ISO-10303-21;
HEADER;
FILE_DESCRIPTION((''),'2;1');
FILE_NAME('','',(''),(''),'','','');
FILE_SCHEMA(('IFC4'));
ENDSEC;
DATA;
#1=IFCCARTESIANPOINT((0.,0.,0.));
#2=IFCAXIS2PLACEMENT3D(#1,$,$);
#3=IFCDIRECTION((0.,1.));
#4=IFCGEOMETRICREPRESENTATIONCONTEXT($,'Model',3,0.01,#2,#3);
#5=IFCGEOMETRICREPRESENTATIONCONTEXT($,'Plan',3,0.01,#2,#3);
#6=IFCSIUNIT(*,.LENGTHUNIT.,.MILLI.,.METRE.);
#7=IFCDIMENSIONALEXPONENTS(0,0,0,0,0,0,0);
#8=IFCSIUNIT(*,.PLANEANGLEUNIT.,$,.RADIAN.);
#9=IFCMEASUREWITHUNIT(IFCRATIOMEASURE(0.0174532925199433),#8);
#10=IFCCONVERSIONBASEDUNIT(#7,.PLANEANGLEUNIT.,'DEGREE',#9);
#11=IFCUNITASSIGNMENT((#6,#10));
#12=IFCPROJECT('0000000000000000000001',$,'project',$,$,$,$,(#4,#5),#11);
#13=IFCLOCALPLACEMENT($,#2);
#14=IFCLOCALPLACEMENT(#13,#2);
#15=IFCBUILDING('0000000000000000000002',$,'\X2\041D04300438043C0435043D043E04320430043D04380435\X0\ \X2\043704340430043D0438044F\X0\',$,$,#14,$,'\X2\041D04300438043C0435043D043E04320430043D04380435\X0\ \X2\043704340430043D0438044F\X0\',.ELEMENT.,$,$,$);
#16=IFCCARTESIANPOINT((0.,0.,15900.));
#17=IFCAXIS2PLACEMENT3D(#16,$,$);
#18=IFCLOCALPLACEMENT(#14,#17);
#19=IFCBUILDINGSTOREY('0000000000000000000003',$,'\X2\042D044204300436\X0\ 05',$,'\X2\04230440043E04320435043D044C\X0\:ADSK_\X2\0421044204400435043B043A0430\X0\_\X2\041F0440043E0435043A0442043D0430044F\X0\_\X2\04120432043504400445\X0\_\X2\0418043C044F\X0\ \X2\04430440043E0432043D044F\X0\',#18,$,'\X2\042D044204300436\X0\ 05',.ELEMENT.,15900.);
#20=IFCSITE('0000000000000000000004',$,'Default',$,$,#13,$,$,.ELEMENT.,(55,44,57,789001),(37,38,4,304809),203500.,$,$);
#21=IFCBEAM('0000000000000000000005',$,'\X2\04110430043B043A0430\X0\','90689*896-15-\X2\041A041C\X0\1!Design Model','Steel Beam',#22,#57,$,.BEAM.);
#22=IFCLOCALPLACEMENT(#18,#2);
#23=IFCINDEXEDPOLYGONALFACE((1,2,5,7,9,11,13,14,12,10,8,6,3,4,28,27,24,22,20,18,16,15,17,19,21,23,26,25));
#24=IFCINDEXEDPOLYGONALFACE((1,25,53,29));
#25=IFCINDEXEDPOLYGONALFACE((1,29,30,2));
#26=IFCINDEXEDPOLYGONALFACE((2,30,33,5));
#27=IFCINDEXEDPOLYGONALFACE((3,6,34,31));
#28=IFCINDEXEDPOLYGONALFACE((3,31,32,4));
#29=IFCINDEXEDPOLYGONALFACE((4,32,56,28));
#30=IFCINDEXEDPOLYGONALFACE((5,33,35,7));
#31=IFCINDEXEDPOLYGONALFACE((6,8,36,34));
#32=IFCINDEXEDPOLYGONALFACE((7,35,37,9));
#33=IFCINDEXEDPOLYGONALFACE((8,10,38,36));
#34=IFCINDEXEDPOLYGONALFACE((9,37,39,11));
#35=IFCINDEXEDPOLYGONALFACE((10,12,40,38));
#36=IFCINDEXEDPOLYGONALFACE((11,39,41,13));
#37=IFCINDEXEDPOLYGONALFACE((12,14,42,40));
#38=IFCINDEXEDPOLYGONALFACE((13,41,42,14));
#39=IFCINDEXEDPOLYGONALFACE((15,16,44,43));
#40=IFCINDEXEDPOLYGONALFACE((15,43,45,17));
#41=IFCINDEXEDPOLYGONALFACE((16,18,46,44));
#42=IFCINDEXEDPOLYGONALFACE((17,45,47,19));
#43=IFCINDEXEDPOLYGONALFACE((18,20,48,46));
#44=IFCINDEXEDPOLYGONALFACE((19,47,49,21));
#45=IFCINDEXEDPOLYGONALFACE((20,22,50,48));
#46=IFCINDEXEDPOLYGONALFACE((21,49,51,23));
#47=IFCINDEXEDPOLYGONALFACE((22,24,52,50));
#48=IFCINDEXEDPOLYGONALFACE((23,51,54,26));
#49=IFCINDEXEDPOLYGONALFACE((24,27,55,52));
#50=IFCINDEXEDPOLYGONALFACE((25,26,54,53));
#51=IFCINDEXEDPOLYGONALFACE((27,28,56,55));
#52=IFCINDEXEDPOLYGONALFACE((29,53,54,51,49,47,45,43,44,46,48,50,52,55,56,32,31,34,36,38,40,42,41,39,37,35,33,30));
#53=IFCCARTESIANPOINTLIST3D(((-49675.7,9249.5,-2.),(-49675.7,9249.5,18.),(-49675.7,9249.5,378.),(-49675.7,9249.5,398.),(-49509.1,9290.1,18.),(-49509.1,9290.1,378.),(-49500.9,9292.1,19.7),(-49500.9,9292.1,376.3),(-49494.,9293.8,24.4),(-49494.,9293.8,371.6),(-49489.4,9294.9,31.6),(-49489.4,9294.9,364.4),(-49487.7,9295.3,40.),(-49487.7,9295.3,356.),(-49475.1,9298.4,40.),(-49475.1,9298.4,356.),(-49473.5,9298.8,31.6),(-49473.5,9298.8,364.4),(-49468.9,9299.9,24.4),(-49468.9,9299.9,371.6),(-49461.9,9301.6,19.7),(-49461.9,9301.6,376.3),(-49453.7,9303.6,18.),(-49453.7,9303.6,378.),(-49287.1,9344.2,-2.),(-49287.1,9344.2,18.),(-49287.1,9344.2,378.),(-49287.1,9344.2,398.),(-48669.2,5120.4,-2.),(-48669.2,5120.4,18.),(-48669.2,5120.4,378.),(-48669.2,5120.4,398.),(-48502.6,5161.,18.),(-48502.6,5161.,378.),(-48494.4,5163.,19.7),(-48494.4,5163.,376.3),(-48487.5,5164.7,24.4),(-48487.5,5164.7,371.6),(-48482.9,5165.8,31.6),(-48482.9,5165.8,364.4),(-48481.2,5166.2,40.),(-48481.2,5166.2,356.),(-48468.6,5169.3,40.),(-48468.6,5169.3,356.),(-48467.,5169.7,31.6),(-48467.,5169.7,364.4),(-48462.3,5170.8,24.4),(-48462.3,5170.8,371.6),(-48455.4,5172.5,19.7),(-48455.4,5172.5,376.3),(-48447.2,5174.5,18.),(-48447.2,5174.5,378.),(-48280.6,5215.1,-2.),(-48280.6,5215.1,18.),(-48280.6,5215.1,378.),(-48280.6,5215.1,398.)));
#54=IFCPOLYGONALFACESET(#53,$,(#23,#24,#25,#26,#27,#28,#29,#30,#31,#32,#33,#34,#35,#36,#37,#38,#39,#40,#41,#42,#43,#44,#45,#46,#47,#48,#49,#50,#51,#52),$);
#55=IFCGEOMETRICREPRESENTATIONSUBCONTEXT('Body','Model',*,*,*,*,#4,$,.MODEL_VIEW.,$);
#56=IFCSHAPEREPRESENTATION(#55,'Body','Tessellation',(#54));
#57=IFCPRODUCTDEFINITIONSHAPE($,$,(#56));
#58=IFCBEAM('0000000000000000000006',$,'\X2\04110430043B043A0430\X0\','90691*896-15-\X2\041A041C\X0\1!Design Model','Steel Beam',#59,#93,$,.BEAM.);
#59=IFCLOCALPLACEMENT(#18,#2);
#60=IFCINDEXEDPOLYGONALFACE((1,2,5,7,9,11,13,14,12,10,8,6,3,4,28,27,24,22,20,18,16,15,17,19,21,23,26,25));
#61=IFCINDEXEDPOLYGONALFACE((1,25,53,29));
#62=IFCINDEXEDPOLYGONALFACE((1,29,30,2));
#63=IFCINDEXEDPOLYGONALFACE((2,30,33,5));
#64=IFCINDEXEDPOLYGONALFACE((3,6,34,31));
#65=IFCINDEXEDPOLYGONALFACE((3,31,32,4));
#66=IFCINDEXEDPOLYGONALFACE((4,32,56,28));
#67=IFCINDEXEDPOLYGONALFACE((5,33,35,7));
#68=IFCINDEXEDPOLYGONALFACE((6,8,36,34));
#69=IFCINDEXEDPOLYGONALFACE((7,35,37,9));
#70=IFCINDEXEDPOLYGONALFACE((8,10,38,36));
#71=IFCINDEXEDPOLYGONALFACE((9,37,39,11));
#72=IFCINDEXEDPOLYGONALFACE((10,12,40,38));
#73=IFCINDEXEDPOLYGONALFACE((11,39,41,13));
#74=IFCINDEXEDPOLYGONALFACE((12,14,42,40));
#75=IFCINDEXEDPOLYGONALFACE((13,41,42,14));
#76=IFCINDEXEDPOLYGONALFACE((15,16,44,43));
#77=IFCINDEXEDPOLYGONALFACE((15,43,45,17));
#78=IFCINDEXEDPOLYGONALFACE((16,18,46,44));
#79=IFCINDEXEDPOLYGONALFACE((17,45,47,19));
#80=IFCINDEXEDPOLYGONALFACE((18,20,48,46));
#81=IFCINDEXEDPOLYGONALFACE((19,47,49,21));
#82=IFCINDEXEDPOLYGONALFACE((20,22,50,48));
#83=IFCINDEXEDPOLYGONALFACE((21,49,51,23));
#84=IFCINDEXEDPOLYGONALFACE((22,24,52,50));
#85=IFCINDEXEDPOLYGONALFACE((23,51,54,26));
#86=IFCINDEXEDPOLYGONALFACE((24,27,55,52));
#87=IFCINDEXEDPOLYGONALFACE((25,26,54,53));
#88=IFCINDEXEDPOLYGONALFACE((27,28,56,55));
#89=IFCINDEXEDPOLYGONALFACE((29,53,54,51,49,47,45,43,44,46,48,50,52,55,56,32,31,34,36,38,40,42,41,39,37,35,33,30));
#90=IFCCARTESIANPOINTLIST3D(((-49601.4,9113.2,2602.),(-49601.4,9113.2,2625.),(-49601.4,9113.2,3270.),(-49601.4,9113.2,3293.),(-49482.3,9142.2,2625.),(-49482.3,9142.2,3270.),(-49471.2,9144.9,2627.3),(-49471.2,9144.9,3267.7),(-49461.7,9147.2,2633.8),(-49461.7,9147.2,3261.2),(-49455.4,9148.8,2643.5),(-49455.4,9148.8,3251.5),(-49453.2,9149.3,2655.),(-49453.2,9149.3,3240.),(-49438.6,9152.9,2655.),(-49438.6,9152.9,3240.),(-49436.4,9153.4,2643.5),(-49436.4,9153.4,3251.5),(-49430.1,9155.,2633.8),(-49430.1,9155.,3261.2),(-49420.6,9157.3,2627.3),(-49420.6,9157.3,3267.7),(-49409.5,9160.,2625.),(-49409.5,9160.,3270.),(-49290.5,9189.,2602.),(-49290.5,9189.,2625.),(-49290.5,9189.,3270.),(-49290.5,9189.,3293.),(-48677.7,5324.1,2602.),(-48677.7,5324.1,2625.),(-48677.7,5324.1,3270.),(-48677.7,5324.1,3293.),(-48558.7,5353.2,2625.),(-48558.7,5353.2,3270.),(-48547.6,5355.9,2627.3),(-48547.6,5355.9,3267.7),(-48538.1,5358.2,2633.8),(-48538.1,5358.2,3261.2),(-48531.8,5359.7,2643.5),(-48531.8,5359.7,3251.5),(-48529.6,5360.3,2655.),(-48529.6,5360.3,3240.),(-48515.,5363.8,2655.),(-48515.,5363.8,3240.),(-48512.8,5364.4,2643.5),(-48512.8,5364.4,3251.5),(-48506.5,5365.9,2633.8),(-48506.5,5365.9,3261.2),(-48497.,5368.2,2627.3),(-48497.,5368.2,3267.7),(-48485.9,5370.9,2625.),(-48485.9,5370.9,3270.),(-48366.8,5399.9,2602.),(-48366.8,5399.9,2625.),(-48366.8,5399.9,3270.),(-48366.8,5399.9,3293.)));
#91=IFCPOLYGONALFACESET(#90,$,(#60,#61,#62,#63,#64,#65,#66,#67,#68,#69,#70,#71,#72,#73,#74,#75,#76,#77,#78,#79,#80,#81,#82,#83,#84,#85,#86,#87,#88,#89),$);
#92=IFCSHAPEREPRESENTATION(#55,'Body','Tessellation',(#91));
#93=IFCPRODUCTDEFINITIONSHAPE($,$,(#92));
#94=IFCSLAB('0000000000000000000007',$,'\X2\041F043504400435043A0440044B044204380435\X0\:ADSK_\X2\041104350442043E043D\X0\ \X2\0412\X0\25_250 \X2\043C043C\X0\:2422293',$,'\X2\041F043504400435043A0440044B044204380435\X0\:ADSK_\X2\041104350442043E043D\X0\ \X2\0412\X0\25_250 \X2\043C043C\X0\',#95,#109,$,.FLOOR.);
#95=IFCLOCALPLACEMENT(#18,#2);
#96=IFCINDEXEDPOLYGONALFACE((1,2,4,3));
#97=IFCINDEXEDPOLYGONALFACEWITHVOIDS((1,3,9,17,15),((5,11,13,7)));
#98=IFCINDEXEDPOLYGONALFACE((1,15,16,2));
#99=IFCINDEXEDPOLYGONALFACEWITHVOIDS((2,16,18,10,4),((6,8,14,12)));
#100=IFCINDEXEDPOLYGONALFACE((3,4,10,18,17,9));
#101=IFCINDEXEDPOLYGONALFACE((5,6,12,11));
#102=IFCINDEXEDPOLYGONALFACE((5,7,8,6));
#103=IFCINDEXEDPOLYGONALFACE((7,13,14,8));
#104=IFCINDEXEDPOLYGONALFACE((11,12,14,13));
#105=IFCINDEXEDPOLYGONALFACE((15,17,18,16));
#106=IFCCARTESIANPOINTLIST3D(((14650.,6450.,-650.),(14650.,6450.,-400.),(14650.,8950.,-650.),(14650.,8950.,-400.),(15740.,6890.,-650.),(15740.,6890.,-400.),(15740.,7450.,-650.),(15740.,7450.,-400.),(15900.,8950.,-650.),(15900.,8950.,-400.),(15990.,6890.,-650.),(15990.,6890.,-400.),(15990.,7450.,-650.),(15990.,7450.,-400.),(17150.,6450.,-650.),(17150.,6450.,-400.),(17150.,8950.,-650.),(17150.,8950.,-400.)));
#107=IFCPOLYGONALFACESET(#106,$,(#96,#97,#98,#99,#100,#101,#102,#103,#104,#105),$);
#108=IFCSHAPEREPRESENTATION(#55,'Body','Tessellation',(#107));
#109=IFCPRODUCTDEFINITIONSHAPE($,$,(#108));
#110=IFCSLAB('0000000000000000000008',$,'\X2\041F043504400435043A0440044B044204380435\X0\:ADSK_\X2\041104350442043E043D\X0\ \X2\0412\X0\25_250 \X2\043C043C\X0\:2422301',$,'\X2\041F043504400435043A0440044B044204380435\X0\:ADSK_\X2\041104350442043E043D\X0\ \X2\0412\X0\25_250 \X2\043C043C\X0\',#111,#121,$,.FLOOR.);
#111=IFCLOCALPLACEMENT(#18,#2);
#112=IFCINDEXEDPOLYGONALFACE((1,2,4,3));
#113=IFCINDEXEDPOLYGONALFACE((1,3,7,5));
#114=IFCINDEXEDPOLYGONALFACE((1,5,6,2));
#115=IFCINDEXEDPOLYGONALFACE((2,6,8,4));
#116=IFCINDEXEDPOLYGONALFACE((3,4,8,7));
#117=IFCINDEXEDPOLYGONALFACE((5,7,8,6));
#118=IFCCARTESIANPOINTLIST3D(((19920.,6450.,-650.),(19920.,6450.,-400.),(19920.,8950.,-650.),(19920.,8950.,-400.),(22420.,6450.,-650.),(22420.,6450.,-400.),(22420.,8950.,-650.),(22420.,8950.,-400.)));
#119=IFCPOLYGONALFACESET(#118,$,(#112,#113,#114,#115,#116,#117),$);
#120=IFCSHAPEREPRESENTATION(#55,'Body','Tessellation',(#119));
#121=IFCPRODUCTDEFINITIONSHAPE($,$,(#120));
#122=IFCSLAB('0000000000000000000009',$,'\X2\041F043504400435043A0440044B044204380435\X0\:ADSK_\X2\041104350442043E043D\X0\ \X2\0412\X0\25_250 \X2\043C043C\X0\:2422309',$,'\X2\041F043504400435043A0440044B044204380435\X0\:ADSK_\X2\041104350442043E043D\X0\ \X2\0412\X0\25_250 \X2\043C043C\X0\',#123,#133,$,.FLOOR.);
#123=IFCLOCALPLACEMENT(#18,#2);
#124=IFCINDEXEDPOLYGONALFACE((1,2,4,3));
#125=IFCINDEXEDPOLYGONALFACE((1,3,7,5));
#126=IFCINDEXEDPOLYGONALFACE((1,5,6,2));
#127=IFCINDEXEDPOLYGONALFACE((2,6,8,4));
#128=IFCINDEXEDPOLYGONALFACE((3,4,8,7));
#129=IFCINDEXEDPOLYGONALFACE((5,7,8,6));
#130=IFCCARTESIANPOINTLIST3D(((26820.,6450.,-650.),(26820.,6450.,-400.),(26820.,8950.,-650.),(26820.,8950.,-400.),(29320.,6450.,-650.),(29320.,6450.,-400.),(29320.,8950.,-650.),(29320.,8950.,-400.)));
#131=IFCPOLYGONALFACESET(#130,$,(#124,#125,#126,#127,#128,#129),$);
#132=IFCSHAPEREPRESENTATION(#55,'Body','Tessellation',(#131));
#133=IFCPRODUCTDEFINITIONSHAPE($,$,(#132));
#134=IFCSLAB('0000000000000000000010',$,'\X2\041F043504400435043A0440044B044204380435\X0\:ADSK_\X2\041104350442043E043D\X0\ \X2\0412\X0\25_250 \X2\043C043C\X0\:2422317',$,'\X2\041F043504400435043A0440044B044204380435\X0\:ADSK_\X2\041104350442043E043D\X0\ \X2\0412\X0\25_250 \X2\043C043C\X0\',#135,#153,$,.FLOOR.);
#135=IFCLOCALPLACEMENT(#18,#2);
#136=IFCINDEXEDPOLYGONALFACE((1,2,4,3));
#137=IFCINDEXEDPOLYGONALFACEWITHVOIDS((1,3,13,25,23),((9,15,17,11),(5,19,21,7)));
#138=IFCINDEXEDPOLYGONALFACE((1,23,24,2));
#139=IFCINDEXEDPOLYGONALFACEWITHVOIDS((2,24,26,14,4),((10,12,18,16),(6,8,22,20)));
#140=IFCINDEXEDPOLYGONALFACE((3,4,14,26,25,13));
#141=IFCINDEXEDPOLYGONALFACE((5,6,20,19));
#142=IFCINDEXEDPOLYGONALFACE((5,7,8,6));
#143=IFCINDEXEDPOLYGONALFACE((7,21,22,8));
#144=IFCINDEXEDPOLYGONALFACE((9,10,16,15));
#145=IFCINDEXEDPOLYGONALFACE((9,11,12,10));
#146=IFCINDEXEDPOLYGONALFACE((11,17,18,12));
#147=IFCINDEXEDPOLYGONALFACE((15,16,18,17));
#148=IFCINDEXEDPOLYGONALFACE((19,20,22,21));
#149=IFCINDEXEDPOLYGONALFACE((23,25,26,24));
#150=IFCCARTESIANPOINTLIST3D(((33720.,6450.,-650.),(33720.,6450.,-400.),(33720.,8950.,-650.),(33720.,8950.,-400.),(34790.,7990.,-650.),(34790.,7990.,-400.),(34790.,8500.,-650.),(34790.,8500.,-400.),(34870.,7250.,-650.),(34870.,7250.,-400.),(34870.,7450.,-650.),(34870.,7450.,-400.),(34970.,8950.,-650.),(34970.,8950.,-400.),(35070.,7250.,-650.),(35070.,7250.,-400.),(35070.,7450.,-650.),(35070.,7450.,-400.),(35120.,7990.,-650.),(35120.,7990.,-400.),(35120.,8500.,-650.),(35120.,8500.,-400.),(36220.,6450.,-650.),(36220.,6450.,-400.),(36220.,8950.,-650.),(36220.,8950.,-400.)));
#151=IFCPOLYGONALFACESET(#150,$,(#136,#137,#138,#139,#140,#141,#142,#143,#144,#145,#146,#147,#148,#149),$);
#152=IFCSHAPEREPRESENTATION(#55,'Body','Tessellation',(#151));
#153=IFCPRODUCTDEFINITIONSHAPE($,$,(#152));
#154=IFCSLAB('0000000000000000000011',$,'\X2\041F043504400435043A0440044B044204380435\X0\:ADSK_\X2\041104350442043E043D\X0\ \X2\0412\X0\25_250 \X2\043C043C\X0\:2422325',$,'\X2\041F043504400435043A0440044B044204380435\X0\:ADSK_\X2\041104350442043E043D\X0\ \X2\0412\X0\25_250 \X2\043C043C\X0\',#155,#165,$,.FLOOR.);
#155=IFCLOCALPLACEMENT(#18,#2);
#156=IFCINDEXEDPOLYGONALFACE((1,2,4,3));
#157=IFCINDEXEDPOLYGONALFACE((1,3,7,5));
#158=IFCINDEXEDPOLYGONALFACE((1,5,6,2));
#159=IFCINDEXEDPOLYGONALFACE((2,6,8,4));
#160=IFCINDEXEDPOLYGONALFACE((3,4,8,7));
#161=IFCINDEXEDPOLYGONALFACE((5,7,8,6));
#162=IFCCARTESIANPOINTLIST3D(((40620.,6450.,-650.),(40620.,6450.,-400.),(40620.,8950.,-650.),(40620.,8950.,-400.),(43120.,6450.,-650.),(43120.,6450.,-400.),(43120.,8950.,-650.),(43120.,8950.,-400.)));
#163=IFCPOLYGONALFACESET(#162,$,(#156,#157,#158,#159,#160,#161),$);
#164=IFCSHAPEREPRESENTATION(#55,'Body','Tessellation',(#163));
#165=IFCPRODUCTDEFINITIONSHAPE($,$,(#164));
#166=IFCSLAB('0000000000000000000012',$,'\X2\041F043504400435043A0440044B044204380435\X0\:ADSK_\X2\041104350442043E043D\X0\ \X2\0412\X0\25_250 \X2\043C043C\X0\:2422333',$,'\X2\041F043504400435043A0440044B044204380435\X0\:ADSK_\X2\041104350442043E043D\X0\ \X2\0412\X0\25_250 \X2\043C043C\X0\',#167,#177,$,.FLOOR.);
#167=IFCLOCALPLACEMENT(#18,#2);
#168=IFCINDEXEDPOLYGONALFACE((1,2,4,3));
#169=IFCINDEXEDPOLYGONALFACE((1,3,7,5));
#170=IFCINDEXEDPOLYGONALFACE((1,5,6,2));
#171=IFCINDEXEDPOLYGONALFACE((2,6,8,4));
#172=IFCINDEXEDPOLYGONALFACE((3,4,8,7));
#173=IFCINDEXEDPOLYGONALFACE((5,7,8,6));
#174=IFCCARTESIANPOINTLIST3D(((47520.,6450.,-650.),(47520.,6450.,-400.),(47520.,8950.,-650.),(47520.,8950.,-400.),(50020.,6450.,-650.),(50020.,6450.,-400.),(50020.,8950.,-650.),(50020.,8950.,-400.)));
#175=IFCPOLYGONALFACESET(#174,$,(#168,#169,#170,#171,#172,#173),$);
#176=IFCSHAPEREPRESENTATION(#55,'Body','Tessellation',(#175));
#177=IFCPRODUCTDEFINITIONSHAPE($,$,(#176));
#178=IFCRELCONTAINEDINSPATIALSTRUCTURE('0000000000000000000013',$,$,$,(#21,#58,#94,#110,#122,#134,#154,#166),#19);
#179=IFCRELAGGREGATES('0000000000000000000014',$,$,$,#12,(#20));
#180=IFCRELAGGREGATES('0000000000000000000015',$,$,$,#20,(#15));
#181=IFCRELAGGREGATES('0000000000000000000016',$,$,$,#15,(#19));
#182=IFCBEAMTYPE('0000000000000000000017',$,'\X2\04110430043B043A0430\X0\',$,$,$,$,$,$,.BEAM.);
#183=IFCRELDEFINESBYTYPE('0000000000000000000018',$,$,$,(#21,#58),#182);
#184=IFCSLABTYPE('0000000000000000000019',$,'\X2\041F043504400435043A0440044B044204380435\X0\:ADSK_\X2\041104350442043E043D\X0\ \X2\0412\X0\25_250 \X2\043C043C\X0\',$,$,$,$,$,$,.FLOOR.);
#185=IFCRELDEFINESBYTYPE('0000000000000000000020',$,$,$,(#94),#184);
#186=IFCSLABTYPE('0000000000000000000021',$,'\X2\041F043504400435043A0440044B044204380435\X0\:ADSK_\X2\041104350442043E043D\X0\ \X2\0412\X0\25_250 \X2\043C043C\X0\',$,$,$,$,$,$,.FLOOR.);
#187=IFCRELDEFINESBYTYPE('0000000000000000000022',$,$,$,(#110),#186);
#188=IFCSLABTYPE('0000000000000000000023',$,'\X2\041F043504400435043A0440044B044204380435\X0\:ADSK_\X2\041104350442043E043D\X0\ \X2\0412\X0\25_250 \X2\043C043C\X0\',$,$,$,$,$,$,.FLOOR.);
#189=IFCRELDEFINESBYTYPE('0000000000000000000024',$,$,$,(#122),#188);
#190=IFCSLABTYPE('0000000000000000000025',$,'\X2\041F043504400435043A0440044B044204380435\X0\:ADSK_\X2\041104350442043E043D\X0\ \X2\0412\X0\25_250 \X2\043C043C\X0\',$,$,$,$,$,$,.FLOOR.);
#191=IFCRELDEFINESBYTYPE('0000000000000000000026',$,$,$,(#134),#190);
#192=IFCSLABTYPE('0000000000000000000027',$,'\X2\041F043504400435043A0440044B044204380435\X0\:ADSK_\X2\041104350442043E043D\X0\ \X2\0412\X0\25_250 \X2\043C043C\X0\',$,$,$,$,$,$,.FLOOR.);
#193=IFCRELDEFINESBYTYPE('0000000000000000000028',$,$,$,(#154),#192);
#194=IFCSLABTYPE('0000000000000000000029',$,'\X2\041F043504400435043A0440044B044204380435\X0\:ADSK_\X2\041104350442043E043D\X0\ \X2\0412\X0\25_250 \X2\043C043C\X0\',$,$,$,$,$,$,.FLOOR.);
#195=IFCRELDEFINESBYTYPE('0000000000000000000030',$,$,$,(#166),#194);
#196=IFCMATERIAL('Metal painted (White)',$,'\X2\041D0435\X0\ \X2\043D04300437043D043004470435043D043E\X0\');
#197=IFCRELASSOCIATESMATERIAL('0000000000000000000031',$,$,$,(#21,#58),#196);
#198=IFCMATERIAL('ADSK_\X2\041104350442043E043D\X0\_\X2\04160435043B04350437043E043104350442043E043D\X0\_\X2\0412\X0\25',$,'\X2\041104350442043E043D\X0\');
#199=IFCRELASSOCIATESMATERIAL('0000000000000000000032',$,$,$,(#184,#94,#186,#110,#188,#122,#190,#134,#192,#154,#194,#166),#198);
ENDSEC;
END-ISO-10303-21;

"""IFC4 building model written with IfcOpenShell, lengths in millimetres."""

from ifc_helpers import new_model, entity, si_unit, converted_unit, direction, frame, origin, place, context, subcontext, project, spatial, indexed_curve, outline, extrude, material, type_object, element, save


model = new_model("IFC4")

# Units and contexts
model_context = context("Model", 3, precision=0.01, world=origin(), true_north=direction((0.0, 1.0)))
plan_context = context("Plan", 3, precision=0.01, world=origin(), true_north=direction((0.0, 1.0)))
body_context = subcontext(model_context, "Body", "Model", "MODEL_VIEW")
ifc_project = project(units=[si_unit("LENGTHUNIT", "METRE", prefix="MILLI"), converted_unit("PLANEANGLEUNIT", "DEGREE", entity("IfcRatioMeasure", 0.0174532925199433), si_unit("PLANEANGLEUNIT", "RADIAN"), dimensions=[0, 0, 0, 0, 0, 0, 0])], contexts=[model_context, plan_context])

# Site, building, storey
site_placement = place(None, origin())
site = spatial("IfcSite", under=ifc_project, at=site_placement, Name="Default", CompositionType="ELEMENT", RefLatitude=(55, 44, 57, 789001), RefLongitude=(37, 38, 4, 304809), RefElevation=203500.0)
building_placement = place(site_placement, origin())
building = spatial("IfcBuilding", under=site, at=building_placement, Name="Наименование здания", LongName="Наименование здания", CompositionType="ELEMENT")
storey_placement = place(building_placement, frame((0.0, 0.0, 15900.0)))
storey = spatial("IfcBuildingStorey", under=building, at=storey_placement, Name="Этаж 05", ObjectType="Уровень:ADSK_Стрелка_Проектная_Вверх_Имя уровня", LongName="Этаж 05", CompositionType="ELEMENT", Elevation=15900.0)

# Shared definitions
placement = place(storey_placement, origin())

# Beams
ifc_material_1 = material(Name="Metal painted (White)", Category="Не назначено")
beam_type = type_object("IfcBeamType", Name="Балка", PredefinedType="BEAM")
element("IfcBeam", 1, at=placement, inside=storey, type_object=beam_type, material=ifc_material_1, Name="Балка", Description="90689*896-15-КМ1!Design Model", ObjectType="Steel Beam", PredefinedType="BEAM", context=body_context, shape_type="SweptSolid", body=[
    extrude(outline(indexed_curve([(-200.0, -200.0), (-180.0, -200.0), (-180.0, -28.5), (-178.3, -20.1), (-173.6, -12.9), (-166.4, -8.2), (-158.0, -6.5), (158.0, -6.5), (166.4, -8.2), (173.6, -12.9), (178.3, -20.1), (180.0, -28.5), (180.0, -200.0), (200.0, -200.0), (200.0, 200.0), (180.0, 200.0), (180.0, 28.5), (178.3, 20.1), (173.6, 12.9), (166.4, 8.2), (158.0, 6.5), (-158.0, 6.5), (-166.4, 8.2), (-173.6, 12.9), (-178.3, 20.1), (-180.0, 28.5), (-180.0, 200.0), (-200.0, 200.0), (-200.0, -200.0)], self_intersect=False)), frame((-48474.9, 5167.7, 198.0), z_axis=(-0.236826, 0.971552, 0.0), x_axis=(0.0, 0.0, 1.0)), (0.0, 0.0, 1.0), 4250.0),
])
element("IfcBeam", 2, at=placement, inside=storey, type_object=beam_type, material=ifc_material_1, Name="Балка", Description="90691*896-15-КМ1!Design Model", ObjectType="Steel Beam", PredefinedType="BEAM", context=body_context, shape_type="SweptSolid", body=[
    extrude(outline(indexed_curve([(-345.5, -160.0), (-322.5, -160.0), (-322.5, -37.5), (-320.2, -26.0), (-313.7, -16.3), (-304.0, -9.8), (-292.5, -7.5), (292.5, -7.5), (304.0, -9.8), (313.7, -16.3), (320.2, -26.0), (322.5, -37.5), (322.5, -160.0), (345.5, -160.0), (345.5, 160.0), (322.5, 160.0), (322.5, 37.5), (320.2, 26.0), (313.7, 16.3), (304.0, 9.8), (292.5, 7.5), (-292.5, 7.5), (-304.0, 9.8), (-313.7, 16.3), (-320.2, 26.0), (-322.5, 37.5), (-322.5, 160.0), (-345.5, 160.0), (-345.5, -160.0)], self_intersect=False)), frame((-48522.3, 5362.0, 2947.5), z_axis=(-0.236826, 0.971552, 0.0), x_axis=(0.0, 0.0, 1.0)), (0.0, 0.0, 1.0), 3900.0),
])

# Slabs
ifc_material_2 = material(Name="ADSK_Бетон_Железобетон_В25", Category="Бетон")
slab_type_1 = type_object("IfcSlabType", Name="Перекрытие:ADSK_Бетон В25_250 мм", PredefinedType="FLOOR", material=ifc_material_2)
element("IfcSlab", 3, at=placement, inside=storey, type_object=slab_type_1, material=ifc_material_2, Name="Перекрытие:ADSK_Бетон В25_250 мм:2422293", ObjectType="Перекрытие:ADSK_Бетон В25_250 мм", PredefinedType="FLOOR", context=body_context, shape_type="SweptSolid", body=[
    extrude(outline(indexed_curve([(-1000.0, -1250.0), (1500.0, -1250.0), (1500.0, 1250.0), (-1000.0, 1250.0), (-1000.0, 0.0), (-1000.0, -1250.0)], self_intersect=False), holes=[indexed_curve([(500.0, 90.0), (1060.0, 90.0), (1060.0, -160.0), (500.0, -160.0), (500.0, 90.0)], self_intersect=False)]), frame((15900.0, 7950.0, -650.0), z_axis=(0.0, 0.0, 1.0), x_axis=(0.0, -1.0, 0.0)), (0.0, 0.0, 1.0), 250.0),
])
slab_type_2 = type_object("IfcSlabType", Name="Перекрытие:ADSK_Бетон В25_250 мм", PredefinedType="FLOOR", material=ifc_material_2)
element("IfcSlab", 4, at=placement, inside=storey, type_object=slab_type_2, material=ifc_material_2, Name="Перекрытие:ADSK_Бетон В25_250 мм:2422301", ObjectType="Перекрытие:ADSK_Бетон В25_250 мм", PredefinedType="FLOOR", context=body_context, shape_type="SweptSolid", body=[
    extrude(outline(indexed_curve([(-1250.0, -1250.0), (1250.0, -1250.0), (1250.0, 1250.0), (-1250.0, 1250.0), (-1250.0, -1250.0)], self_intersect=False)), frame((21170.0, 7700.0, -400.0), z_axis=(0.0, 0.0, -1.0), x_axis=(0.0, 1.0, 0.0)), (0.0, 0.0, 1.0), 250.0),
])
slab_type_3 = type_object("IfcSlabType", Name="Перекрытие:ADSK_Бетон В25_250 мм", PredefinedType="FLOOR", material=ifc_material_2)
element("IfcSlab", 5, at=placement, inside=storey, type_object=slab_type_3, material=ifc_material_2, Name="Перекрытие:ADSK_Бетон В25_250 мм:2422309", ObjectType="Перекрытие:ADSK_Бетон В25_250 мм", PredefinedType="FLOOR", context=body_context, shape_type="SweptSolid", body=[
    extrude(outline(indexed_curve([(-1250.0, -1250.0), (1250.0, -1250.0), (1250.0, 1250.0), (-1250.0, 1250.0), (-1250.0, -1250.0)], self_intersect=False)), frame((28070.0, 7700.0, -400.0), z_axis=(0.0, 0.0, -1.0), x_axis=(0.0, 1.0, 0.0)), (0.0, 0.0, 1.0), 250.0),
])
slab_type_4 = type_object("IfcSlabType", Name="Перекрытие:ADSK_Бетон В25_250 мм", PredefinedType="FLOOR", material=ifc_material_2)
element("IfcSlab", 6, at=placement, inside=storey, type_object=slab_type_4, material=ifc_material_2, Name="Перекрытие:ADSK_Бетон В25_250 мм:2422317", ObjectType="Перекрытие:ADSK_Бетон В25_250 мм", PredefinedType="FLOOR", context=body_context, shape_type="SweptSolid", body=[
    extrude(outline(indexed_curve([(-1000.0, -1250.0), (1500.0, -1250.0), (1500.0, 1250.0), (-1000.0, 1250.0), (-1000.0, 0.0), (-1000.0, -1250.0)], self_intersect=False), holes=[indexed_curve([(500.0, 100.0), (700.0, 100.0), (700.0, -100.0), (500.0, -100.0), (500.0, 100.0)], self_intersect=False), indexed_curve([(-550.0, 150.0), (-40.0, 150.0), (-40.0, -180.0), (-550.0, -180.0), (-550.0, 150.0)], self_intersect=False)]), frame((34970.0, 7950.0, -650.0), z_axis=(0.0, 0.0, 1.0), x_axis=(0.0, -1.0, 0.0)), (0.0, 0.0, 1.0), 250.0),
])
slab_type_5 = type_object("IfcSlabType", Name="Перекрытие:ADSK_Бетон В25_250 мм", PredefinedType="FLOOR", material=ifc_material_2)
element("IfcSlab", 7, at=placement, inside=storey, type_object=slab_type_5, material=ifc_material_2, Name="Перекрытие:ADSK_Бетон В25_250 мм:2422325", ObjectType="Перекрытие:ADSK_Бетон В25_250 мм", PredefinedType="FLOOR", context=body_context, shape_type="SweptSolid", body=[
    extrude(outline(indexed_curve([(-1250.0, -1250.0), (1250.0, -1250.0), (1250.0, 1250.0), (-1250.0, 1250.0), (-1250.0, -1250.0)], self_intersect=False)), frame((41870.0, 7700.0, -400.0), z_axis=(0.0, 0.0, -1.0), x_axis=(0.0, 1.0, 0.0)), (0.0, 0.0, 1.0), 250.0),
])
slab_type_6 = type_object("IfcSlabType", Name="Перекрытие:ADSK_Бетон В25_250 мм", PredefinedType="FLOOR", material=ifc_material_2)
element("IfcSlab", 8, at=placement, inside=storey, type_object=slab_type_6, material=ifc_material_2, Name="Перекрытие:ADSK_Бетон В25_250 мм:2422333", ObjectType="Перекрытие:ADSK_Бетон В25_250 мм", PredefinedType="FLOOR", context=body_context, shape_type="SweptSolid", body=[
    extrude(outline(indexed_curve([(-1250.0, -1250.0), (1250.0, -1250.0), (1250.0, 1250.0), (-1250.0, 1250.0), (-1250.0, -1250.0)], self_intersect=False)), frame((48770.0, 7700.0, -400.0), z_axis=(0.0, 0.0, -1.0), x_axis=(0.0, 1.0, 0.0)), (0.0, 0.0, 1.0), 250.0),
])

save(model, "model.ifc")
